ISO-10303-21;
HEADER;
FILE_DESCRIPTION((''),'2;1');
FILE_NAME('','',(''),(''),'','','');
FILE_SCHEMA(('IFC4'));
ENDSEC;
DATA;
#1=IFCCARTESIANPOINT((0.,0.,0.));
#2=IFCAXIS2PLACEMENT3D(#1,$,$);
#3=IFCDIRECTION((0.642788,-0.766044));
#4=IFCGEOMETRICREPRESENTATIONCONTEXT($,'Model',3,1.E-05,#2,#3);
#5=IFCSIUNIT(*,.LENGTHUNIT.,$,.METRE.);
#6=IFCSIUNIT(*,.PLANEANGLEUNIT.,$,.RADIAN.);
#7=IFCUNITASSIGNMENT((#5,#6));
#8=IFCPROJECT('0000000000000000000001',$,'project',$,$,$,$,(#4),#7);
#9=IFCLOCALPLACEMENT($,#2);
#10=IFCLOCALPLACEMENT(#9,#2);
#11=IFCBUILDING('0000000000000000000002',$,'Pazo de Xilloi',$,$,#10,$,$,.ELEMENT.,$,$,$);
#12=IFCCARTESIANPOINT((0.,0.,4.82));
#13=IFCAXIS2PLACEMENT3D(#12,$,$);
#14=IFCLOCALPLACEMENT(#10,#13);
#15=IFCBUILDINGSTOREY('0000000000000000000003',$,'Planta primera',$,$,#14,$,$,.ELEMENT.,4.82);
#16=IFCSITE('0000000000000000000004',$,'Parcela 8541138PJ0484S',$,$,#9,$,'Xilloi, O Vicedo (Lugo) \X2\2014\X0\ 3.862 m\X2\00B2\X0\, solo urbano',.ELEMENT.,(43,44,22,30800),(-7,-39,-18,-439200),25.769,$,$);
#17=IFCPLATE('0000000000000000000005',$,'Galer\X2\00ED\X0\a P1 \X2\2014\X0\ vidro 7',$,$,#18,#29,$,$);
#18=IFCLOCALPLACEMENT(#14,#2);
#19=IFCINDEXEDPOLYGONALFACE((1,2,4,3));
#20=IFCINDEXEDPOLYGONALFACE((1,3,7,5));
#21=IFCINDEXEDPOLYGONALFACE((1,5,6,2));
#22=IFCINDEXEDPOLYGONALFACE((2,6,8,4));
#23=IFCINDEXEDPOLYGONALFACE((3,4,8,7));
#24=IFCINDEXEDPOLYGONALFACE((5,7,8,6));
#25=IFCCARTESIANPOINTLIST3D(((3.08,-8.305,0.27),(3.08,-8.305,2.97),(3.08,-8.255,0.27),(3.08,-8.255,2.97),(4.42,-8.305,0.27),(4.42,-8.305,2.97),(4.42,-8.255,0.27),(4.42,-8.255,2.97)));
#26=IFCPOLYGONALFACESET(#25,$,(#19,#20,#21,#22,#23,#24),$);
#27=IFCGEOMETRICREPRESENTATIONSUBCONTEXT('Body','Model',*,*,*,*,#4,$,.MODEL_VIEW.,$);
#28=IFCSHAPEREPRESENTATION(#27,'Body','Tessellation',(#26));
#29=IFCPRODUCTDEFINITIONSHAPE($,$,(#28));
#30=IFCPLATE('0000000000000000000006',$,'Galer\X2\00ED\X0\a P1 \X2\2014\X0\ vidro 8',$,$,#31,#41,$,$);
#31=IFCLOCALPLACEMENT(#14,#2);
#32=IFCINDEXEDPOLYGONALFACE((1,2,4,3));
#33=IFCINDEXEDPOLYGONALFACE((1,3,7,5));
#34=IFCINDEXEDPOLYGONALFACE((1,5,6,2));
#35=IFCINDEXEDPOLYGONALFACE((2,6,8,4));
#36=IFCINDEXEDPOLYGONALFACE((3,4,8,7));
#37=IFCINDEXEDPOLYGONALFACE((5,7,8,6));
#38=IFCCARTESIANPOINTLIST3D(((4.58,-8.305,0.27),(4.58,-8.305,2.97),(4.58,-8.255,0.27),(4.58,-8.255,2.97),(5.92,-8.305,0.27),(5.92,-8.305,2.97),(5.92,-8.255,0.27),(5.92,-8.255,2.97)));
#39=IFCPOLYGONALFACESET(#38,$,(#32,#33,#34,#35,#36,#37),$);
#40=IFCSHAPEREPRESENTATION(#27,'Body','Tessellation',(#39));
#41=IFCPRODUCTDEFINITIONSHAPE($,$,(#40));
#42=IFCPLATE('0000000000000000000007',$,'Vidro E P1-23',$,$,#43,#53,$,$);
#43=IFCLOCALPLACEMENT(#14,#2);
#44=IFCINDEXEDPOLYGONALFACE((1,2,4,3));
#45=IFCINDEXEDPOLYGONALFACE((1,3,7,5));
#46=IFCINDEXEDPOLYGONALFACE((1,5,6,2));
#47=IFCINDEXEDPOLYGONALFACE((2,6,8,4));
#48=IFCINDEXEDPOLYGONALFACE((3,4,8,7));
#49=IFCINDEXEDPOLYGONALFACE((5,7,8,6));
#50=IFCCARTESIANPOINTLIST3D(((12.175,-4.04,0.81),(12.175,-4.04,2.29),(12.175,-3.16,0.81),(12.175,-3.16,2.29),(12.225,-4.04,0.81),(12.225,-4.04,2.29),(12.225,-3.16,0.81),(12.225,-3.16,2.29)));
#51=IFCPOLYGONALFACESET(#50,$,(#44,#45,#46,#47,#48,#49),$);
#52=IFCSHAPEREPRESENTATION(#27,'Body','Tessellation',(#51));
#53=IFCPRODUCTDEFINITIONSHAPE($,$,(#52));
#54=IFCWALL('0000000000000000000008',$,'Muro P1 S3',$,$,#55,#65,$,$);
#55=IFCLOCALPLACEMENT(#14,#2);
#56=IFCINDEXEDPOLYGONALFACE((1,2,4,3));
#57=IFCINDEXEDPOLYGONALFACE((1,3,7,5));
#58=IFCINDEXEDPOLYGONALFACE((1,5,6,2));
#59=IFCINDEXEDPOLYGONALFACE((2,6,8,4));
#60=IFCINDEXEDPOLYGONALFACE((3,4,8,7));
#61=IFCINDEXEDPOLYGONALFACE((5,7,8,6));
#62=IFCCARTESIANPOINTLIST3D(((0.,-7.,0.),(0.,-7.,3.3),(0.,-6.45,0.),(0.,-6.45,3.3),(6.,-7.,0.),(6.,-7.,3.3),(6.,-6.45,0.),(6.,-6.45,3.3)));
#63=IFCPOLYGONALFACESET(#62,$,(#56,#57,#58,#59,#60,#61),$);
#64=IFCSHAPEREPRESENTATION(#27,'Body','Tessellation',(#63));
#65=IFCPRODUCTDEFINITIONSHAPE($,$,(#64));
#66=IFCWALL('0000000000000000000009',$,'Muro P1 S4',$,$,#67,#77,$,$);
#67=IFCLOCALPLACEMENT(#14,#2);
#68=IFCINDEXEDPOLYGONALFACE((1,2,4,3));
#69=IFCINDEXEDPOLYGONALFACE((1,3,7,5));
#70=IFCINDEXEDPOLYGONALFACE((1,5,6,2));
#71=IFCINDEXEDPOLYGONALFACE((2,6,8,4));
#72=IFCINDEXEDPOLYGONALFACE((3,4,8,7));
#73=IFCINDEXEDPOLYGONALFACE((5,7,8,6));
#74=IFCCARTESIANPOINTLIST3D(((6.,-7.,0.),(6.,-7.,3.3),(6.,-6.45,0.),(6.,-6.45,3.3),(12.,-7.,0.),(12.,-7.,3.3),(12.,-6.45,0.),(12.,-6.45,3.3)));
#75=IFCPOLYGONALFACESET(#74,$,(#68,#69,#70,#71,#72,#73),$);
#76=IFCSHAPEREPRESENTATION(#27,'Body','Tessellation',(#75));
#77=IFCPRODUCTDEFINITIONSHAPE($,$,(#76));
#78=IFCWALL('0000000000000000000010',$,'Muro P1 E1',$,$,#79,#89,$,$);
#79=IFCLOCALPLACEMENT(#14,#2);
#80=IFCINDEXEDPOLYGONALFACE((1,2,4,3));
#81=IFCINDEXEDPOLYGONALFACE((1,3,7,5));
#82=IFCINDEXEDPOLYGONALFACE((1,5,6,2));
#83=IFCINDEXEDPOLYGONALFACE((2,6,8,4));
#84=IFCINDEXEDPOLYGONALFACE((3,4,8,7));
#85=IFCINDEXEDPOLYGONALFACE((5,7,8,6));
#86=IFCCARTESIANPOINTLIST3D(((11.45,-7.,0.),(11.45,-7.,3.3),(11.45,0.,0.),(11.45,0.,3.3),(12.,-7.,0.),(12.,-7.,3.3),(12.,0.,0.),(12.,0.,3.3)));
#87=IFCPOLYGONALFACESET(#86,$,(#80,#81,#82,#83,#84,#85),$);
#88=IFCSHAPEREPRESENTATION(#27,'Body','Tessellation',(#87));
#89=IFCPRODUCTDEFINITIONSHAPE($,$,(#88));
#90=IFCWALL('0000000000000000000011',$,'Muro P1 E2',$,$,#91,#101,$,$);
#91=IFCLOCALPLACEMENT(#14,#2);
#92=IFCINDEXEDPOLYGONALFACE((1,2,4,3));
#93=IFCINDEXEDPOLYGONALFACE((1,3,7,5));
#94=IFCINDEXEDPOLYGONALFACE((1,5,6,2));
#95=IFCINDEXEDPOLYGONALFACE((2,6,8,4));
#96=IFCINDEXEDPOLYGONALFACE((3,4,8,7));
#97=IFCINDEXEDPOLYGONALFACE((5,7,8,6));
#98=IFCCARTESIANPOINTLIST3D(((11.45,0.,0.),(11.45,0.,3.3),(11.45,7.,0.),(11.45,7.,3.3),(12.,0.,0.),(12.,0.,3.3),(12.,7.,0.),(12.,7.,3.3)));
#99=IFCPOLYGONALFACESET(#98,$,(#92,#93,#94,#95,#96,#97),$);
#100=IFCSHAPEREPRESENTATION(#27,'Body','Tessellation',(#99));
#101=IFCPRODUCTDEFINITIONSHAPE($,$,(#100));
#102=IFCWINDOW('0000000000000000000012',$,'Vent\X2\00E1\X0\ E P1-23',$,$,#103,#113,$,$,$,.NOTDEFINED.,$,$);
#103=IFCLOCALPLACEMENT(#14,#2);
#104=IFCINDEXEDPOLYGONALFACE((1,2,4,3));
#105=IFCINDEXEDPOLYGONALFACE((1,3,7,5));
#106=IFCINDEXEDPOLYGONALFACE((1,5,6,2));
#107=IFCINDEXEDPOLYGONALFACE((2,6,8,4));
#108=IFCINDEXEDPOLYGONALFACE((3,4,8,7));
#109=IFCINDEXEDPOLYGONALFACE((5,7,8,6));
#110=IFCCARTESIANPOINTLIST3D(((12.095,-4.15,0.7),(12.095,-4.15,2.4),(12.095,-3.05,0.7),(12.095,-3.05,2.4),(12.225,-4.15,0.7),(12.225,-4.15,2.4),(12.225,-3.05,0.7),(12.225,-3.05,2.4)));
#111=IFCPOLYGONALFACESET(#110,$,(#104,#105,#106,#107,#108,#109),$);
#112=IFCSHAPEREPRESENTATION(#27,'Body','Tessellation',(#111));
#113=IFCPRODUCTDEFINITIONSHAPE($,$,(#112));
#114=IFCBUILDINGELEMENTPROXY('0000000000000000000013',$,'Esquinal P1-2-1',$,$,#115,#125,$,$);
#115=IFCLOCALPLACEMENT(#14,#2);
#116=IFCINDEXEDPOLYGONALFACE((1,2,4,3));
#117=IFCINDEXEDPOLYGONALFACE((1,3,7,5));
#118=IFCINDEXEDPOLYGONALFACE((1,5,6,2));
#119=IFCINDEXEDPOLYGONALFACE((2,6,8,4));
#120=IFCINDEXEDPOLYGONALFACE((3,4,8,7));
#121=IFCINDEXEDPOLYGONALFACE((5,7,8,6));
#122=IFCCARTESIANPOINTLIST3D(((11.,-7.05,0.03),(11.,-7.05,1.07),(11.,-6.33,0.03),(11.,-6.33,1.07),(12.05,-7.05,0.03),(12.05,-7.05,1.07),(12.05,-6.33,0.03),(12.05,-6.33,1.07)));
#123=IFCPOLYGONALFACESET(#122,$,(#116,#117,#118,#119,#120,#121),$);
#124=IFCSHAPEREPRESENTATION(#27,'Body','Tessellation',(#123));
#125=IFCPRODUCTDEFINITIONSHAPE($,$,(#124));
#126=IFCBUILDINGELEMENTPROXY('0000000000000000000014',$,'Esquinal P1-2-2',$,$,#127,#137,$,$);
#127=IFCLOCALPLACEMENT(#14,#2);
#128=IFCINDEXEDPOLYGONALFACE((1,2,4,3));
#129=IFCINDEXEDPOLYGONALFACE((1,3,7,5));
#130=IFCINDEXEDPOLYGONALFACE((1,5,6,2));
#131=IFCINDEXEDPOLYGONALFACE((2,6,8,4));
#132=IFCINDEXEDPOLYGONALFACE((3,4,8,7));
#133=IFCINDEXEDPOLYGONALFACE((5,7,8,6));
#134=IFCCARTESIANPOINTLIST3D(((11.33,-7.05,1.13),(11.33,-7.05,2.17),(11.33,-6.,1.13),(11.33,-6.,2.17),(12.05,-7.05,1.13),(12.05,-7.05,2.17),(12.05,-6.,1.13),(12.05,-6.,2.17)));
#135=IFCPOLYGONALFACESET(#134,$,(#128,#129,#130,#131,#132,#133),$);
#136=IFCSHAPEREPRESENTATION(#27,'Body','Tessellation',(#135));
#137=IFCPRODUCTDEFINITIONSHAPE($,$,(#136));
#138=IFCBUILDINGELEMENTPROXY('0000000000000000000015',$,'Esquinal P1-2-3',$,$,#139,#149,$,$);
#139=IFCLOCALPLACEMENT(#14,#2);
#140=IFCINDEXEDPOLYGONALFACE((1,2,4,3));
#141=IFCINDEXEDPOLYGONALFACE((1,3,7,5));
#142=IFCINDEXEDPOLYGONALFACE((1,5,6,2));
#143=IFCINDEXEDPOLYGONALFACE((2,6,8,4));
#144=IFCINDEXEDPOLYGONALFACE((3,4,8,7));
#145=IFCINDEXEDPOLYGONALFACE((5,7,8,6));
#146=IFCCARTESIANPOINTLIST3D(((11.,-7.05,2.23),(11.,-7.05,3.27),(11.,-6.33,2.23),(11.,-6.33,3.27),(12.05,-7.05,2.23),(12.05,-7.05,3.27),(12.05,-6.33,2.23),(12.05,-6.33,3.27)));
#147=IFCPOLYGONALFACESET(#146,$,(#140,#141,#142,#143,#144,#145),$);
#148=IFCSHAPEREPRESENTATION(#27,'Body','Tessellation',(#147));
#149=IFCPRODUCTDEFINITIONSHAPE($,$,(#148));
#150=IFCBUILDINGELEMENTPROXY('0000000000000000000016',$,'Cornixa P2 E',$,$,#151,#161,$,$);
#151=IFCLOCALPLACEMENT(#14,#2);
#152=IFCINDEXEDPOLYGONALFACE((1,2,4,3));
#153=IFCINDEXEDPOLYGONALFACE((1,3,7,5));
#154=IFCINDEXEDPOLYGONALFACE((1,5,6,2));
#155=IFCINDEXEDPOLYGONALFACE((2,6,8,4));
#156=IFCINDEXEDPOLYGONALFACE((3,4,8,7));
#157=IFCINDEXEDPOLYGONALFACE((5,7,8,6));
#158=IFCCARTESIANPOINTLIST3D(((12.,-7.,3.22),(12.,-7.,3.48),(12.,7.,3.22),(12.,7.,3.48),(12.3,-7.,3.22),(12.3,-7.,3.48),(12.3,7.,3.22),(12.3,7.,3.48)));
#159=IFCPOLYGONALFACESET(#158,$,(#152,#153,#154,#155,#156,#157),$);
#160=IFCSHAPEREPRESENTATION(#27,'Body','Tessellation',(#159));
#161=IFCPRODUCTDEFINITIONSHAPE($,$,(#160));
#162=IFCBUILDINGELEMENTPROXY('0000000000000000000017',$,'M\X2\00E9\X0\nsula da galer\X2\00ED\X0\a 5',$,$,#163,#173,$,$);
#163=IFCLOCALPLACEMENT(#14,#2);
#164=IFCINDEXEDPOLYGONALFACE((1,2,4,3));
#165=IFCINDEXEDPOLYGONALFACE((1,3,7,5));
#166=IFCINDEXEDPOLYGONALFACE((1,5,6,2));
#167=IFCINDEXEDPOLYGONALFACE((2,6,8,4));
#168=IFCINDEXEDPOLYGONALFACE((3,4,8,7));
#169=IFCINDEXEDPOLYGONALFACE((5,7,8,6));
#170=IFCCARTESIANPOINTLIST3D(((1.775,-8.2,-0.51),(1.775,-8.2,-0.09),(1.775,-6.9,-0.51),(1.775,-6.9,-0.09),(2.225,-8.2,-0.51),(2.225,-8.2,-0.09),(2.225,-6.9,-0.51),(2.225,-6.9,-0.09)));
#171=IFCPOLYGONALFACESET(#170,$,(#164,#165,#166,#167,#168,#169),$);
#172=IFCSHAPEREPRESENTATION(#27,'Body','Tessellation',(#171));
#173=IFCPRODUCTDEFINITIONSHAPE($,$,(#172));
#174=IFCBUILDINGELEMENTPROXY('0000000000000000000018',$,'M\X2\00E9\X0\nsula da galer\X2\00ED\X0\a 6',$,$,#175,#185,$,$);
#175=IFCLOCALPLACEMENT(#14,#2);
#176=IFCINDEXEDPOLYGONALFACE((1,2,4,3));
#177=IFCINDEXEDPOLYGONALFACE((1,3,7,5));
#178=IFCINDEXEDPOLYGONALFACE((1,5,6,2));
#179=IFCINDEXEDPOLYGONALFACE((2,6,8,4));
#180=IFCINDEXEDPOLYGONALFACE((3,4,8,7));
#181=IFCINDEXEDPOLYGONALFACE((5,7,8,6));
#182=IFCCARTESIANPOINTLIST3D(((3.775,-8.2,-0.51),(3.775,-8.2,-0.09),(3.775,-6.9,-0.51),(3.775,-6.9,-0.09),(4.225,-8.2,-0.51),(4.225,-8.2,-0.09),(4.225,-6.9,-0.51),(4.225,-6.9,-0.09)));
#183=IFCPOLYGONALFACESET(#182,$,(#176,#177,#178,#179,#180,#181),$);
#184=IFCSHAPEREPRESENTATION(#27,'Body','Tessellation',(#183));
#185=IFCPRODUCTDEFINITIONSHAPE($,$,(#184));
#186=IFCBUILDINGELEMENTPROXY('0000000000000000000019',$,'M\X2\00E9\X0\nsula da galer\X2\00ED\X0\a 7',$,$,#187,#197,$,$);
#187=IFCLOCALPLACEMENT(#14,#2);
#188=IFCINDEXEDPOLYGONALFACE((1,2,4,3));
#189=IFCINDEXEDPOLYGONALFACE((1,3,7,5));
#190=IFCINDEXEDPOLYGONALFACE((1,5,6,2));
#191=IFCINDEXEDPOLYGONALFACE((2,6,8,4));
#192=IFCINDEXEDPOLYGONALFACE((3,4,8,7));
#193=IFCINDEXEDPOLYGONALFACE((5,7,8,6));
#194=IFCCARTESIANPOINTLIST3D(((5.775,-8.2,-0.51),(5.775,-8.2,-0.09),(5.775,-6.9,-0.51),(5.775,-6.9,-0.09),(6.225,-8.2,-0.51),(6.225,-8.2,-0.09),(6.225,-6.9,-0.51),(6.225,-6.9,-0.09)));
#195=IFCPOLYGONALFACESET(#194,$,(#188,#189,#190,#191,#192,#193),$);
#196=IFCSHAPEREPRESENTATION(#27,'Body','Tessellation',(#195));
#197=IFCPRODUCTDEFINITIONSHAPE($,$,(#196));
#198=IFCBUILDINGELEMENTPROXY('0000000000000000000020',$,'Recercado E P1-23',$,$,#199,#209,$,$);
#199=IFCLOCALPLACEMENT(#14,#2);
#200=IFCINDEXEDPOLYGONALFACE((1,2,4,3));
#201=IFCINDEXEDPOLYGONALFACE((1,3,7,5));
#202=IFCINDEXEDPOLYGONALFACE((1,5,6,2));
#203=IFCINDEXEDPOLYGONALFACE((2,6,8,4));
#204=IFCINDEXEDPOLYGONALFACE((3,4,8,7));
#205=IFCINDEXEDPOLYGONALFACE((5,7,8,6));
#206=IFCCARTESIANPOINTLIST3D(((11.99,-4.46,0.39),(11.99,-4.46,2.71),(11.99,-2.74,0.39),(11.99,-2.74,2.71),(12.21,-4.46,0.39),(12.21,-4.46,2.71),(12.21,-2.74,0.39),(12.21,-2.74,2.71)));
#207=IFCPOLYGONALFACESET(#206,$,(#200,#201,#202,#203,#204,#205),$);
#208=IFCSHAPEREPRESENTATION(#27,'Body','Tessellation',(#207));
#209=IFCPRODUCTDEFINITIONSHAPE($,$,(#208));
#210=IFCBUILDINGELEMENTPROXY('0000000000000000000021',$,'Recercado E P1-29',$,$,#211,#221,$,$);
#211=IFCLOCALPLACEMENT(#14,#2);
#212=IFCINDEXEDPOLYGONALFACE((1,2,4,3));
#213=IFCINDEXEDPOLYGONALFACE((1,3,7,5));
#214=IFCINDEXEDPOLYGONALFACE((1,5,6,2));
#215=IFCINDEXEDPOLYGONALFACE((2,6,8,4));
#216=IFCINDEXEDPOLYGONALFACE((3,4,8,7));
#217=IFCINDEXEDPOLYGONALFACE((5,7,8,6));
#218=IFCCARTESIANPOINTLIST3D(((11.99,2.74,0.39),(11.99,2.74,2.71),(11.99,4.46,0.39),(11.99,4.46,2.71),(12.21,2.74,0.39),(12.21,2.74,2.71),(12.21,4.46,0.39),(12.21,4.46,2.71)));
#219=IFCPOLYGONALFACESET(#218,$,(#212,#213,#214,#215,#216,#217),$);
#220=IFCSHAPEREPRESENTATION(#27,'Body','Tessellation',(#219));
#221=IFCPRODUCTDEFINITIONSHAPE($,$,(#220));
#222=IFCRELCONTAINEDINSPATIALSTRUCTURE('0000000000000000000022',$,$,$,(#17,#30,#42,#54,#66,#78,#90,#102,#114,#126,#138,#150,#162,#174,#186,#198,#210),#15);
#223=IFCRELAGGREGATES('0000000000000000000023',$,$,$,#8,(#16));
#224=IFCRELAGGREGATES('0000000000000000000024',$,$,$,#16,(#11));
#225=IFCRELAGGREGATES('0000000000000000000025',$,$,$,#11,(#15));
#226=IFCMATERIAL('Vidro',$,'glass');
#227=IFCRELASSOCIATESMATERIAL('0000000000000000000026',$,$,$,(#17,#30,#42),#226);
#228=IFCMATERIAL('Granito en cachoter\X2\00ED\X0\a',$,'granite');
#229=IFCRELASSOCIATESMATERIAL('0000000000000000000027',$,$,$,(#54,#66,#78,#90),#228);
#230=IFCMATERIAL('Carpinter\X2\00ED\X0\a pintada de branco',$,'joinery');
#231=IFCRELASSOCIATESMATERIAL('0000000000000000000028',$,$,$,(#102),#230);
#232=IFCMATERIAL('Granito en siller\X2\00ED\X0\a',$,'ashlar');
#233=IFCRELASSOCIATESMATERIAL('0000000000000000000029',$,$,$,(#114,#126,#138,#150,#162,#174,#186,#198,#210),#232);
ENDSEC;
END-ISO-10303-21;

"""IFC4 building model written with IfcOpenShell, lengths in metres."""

from ifc_helpers import new_model, si_unit, direction, frame, origin, origin_2d, place, context, subcontext, project, spatial, rectangle, extrude, material, element, save


model = new_model("IFC4")

# Units and contexts
model_context = context("Model", 3, precision=1e-05, world=origin(), true_north=direction((0.642788, -0.766044)))
body_context = subcontext(model_context, "Body", "Model", "MODEL_VIEW")
ifc_project = project(units=[si_unit("LENGTHUNIT", "METRE"), si_unit("PLANEANGLEUNIT", "RADIAN")], contexts=[model_context])

# Site, building, storey
site_placement = place(None, origin())
site = spatial("IfcSite", under=ifc_project, at=site_placement, Name="Parcela 8541138PJ0484S", LongName="Xilloi, O Vicedo (Lugo) — 3.862 m², solo urbano", CompositionType="ELEMENT", RefLatitude=(43, 44, 22, 30800), RefLongitude=(-7, -39, -18, -439200), RefElevation=25.769)
building_placement = place(site_placement, origin())
building = spatial("IfcBuilding", under=site, at=building_placement, Name="Pazo de Xilloi", CompositionType="ELEMENT")
storey_placement = place(building_placement, frame((0.0, 0.0, 4.82)))
storey = spatial("IfcBuildingStorey", under=building, at=storey_placement, Name="Planta primera", CompositionType="ELEMENT", Elevation=4.82)

# Shared definitions
ifc_material_1 = material(Name="Carpintería pintada de branco", Category="joinery")

# Plates
ifc_material_2 = material(Name="Vidro", Category="glass")
for number, where, name in (
    (1, (3.75, -8.28, 1.62), "Galería P1 — vidro 7"),
    (2, (5.25, -8.28, 1.62), "Galería P1 — vidro 8"),
):
    element("IfcPlate", number, at=place(storey_placement, frame(where)), inside=storey, material=ifc_material_2, Name=name, context=body_context, shape_type="SweptSolid", body=[
        extrude(rectangle(XDim=1.34, YDim=0.05, at=origin_2d()), frame((0.0, 0.0, -1.35)), (0.0, 0.0, 1.0), 2.7),
    ])
plate_1_placement = place(storey_placement, frame((12.2, -3.6, 1.55)))
element("IfcPlate", 3, at=plate_1_placement, inside=storey, material=ifc_material_2, Name="Vidro E P1-23", context=body_context, shape_type="SweptSolid", body=[
    extrude(rectangle(XDim=0.05, YDim=0.88, at=origin_2d()), frame((0.0, 0.0, -0.74)), (0.0, 0.0, 1.0), 1.48),
])

# Walls
ifc_material_3 = material(Name="Granito en cachotería", Category="granite")
for number, where, name in (
    (4, (3.0, -6.725, 1.65), "Muro P1 S3"),
    (5, (9.0, -6.725, 1.65), "Muro P1 S4"),
):
    element("IfcWall", number, at=place(storey_placement, frame(where)), inside=storey, material=ifc_material_3, Name=name, context=body_context, shape_type="SweptSolid", body=[
        extrude(rectangle(XDim=6.0, YDim=0.55, at=origin_2d()), frame((0.0, 0.0, -1.65)), (0.0, 0.0, 1.0), 3.3),
    ])
for number, where, name in (
    (6, (11.725, -3.5, 1.65), "Muro P1 E1"),
    (7, (11.725, 3.5, 1.65), "Muro P1 E2"),
):
    element("IfcWall", number, at=place(storey_placement, frame(where)), inside=storey, material=ifc_material_3, Name=name, context=body_context, shape_type="SweptSolid", body=[
        extrude(rectangle(XDim=0.55, YDim=7.0, at=origin_2d()), frame((0.0, 0.0, -1.65)), (0.0, 0.0, 1.0), 3.3),
    ])

# Window
window_placement = place(storey_placement, frame((12.16, -3.6, 1.55)))
element("IfcWindow", 8, at=window_placement, inside=storey, material=ifc_material_1, Name="Ventá E P1-23", PredefinedType="NOTDEFINED", context=body_context, shape_type="SweptSolid", body=[
    extrude(rectangle(XDim=0.13, YDim=1.1, at=origin_2d()), frame((0.0, 0.0, -0.85)), (0.0, 0.0, 1.0), 1.7),
])

# Building element proxies
ifc_material_4 = material(Name="Granito en sillería", Category="ashlar")
proxy_1_placement = place(storey_placement, frame((11.525, -6.69, 0.55)))
element("IfcBuildingElementProxy", 9, at=proxy_1_placement, inside=storey, material=ifc_material_4, Name="Esquinal P1-2-1", context=body_context, shape_type="SweptSolid", body=[
    extrude(rectangle(XDim=1.05, YDim=0.72, at=origin_2d()), frame((0.0, 0.0, -0.52)), (0.0, 0.0, 1.0), 1.04),
])
proxy_2_placement = place(storey_placement, frame((11.69, -6.525, 1.65)))
element("IfcBuildingElementProxy", 10, at=proxy_2_placement, inside=storey, material=ifc_material_4, Name="Esquinal P1-2-2", context=body_context, shape_type="SweptSolid", body=[
    extrude(rectangle(XDim=0.72, YDim=1.05, at=origin_2d()), frame((0.0, 0.0, -0.52)), (0.0, 0.0, 1.0), 1.04),
])
proxy_3_placement = place(storey_placement, frame((11.525, -6.69, 2.75)))
element("IfcBuildingElementProxy", 11, at=proxy_3_placement, inside=storey, material=ifc_material_4, Name="Esquinal P1-2-3", context=body_context, shape_type="SweptSolid", body=[
    extrude(rectangle(XDim=1.05, YDim=0.72, at=origin_2d()), frame((0.0, 0.0, -0.52)), (0.0, 0.0, 1.0), 1.04),
])
proxy_4_placement = place(storey_placement, frame((12.15, 0.0, 3.35)))
element("IfcBuildingElementProxy", 12, at=proxy_4_placement, inside=storey, material=ifc_material_4, Name="Cornixa P2 E", context=body_context, shape_type="SweptSolid", body=[
    extrude(rectangle(XDim=0.3, YDim=14.0, at=origin_2d()), frame((0.0, 0.0, -0.13)), (0.0, 0.0, 1.0), 0.26),
])
for number, where, name in (
    (13, (2.0, -7.55, -0.3), "Ménsula da galería 5"),
    (14, (4.0, -7.55, -0.3), "Ménsula da galería 6"),
    (15, (6.0, -7.55, -0.3), "Ménsula da galería 7"),
):
    element("IfcBuildingElementProxy", number, at=place(storey_placement, frame(where)), inside=storey, material=ifc_material_4, Name=name, context=body_context, shape_type="SweptSolid", body=[
        extrude(rectangle(XDim=0.45, YDim=1.3, at=origin_2d()), frame((0.0, 0.0, -0.21)), (0.0, 0.0, 1.0), 0.42),
    ])
for number, where, name in (
    (16, (12.1, -3.6, 1.55), "Recercado E P1-23"),
    (17, (12.1, 3.6, 1.55), "Recercado E P1-29"),
):
    element("IfcBuildingElementProxy", number, at=place(storey_placement, frame(where)), inside=storey, material=ifc_material_4, Name=name, context=body_context, shape_type="SweptSolid", body=[
        extrude(rectangle(XDim=0.22, YDim=1.72, at=origin_2d()), frame((0.0, 0.0, -1.16)), (0.0, 0.0, 1.0), 2.32),
    ])

save(model, "model.ifc")
